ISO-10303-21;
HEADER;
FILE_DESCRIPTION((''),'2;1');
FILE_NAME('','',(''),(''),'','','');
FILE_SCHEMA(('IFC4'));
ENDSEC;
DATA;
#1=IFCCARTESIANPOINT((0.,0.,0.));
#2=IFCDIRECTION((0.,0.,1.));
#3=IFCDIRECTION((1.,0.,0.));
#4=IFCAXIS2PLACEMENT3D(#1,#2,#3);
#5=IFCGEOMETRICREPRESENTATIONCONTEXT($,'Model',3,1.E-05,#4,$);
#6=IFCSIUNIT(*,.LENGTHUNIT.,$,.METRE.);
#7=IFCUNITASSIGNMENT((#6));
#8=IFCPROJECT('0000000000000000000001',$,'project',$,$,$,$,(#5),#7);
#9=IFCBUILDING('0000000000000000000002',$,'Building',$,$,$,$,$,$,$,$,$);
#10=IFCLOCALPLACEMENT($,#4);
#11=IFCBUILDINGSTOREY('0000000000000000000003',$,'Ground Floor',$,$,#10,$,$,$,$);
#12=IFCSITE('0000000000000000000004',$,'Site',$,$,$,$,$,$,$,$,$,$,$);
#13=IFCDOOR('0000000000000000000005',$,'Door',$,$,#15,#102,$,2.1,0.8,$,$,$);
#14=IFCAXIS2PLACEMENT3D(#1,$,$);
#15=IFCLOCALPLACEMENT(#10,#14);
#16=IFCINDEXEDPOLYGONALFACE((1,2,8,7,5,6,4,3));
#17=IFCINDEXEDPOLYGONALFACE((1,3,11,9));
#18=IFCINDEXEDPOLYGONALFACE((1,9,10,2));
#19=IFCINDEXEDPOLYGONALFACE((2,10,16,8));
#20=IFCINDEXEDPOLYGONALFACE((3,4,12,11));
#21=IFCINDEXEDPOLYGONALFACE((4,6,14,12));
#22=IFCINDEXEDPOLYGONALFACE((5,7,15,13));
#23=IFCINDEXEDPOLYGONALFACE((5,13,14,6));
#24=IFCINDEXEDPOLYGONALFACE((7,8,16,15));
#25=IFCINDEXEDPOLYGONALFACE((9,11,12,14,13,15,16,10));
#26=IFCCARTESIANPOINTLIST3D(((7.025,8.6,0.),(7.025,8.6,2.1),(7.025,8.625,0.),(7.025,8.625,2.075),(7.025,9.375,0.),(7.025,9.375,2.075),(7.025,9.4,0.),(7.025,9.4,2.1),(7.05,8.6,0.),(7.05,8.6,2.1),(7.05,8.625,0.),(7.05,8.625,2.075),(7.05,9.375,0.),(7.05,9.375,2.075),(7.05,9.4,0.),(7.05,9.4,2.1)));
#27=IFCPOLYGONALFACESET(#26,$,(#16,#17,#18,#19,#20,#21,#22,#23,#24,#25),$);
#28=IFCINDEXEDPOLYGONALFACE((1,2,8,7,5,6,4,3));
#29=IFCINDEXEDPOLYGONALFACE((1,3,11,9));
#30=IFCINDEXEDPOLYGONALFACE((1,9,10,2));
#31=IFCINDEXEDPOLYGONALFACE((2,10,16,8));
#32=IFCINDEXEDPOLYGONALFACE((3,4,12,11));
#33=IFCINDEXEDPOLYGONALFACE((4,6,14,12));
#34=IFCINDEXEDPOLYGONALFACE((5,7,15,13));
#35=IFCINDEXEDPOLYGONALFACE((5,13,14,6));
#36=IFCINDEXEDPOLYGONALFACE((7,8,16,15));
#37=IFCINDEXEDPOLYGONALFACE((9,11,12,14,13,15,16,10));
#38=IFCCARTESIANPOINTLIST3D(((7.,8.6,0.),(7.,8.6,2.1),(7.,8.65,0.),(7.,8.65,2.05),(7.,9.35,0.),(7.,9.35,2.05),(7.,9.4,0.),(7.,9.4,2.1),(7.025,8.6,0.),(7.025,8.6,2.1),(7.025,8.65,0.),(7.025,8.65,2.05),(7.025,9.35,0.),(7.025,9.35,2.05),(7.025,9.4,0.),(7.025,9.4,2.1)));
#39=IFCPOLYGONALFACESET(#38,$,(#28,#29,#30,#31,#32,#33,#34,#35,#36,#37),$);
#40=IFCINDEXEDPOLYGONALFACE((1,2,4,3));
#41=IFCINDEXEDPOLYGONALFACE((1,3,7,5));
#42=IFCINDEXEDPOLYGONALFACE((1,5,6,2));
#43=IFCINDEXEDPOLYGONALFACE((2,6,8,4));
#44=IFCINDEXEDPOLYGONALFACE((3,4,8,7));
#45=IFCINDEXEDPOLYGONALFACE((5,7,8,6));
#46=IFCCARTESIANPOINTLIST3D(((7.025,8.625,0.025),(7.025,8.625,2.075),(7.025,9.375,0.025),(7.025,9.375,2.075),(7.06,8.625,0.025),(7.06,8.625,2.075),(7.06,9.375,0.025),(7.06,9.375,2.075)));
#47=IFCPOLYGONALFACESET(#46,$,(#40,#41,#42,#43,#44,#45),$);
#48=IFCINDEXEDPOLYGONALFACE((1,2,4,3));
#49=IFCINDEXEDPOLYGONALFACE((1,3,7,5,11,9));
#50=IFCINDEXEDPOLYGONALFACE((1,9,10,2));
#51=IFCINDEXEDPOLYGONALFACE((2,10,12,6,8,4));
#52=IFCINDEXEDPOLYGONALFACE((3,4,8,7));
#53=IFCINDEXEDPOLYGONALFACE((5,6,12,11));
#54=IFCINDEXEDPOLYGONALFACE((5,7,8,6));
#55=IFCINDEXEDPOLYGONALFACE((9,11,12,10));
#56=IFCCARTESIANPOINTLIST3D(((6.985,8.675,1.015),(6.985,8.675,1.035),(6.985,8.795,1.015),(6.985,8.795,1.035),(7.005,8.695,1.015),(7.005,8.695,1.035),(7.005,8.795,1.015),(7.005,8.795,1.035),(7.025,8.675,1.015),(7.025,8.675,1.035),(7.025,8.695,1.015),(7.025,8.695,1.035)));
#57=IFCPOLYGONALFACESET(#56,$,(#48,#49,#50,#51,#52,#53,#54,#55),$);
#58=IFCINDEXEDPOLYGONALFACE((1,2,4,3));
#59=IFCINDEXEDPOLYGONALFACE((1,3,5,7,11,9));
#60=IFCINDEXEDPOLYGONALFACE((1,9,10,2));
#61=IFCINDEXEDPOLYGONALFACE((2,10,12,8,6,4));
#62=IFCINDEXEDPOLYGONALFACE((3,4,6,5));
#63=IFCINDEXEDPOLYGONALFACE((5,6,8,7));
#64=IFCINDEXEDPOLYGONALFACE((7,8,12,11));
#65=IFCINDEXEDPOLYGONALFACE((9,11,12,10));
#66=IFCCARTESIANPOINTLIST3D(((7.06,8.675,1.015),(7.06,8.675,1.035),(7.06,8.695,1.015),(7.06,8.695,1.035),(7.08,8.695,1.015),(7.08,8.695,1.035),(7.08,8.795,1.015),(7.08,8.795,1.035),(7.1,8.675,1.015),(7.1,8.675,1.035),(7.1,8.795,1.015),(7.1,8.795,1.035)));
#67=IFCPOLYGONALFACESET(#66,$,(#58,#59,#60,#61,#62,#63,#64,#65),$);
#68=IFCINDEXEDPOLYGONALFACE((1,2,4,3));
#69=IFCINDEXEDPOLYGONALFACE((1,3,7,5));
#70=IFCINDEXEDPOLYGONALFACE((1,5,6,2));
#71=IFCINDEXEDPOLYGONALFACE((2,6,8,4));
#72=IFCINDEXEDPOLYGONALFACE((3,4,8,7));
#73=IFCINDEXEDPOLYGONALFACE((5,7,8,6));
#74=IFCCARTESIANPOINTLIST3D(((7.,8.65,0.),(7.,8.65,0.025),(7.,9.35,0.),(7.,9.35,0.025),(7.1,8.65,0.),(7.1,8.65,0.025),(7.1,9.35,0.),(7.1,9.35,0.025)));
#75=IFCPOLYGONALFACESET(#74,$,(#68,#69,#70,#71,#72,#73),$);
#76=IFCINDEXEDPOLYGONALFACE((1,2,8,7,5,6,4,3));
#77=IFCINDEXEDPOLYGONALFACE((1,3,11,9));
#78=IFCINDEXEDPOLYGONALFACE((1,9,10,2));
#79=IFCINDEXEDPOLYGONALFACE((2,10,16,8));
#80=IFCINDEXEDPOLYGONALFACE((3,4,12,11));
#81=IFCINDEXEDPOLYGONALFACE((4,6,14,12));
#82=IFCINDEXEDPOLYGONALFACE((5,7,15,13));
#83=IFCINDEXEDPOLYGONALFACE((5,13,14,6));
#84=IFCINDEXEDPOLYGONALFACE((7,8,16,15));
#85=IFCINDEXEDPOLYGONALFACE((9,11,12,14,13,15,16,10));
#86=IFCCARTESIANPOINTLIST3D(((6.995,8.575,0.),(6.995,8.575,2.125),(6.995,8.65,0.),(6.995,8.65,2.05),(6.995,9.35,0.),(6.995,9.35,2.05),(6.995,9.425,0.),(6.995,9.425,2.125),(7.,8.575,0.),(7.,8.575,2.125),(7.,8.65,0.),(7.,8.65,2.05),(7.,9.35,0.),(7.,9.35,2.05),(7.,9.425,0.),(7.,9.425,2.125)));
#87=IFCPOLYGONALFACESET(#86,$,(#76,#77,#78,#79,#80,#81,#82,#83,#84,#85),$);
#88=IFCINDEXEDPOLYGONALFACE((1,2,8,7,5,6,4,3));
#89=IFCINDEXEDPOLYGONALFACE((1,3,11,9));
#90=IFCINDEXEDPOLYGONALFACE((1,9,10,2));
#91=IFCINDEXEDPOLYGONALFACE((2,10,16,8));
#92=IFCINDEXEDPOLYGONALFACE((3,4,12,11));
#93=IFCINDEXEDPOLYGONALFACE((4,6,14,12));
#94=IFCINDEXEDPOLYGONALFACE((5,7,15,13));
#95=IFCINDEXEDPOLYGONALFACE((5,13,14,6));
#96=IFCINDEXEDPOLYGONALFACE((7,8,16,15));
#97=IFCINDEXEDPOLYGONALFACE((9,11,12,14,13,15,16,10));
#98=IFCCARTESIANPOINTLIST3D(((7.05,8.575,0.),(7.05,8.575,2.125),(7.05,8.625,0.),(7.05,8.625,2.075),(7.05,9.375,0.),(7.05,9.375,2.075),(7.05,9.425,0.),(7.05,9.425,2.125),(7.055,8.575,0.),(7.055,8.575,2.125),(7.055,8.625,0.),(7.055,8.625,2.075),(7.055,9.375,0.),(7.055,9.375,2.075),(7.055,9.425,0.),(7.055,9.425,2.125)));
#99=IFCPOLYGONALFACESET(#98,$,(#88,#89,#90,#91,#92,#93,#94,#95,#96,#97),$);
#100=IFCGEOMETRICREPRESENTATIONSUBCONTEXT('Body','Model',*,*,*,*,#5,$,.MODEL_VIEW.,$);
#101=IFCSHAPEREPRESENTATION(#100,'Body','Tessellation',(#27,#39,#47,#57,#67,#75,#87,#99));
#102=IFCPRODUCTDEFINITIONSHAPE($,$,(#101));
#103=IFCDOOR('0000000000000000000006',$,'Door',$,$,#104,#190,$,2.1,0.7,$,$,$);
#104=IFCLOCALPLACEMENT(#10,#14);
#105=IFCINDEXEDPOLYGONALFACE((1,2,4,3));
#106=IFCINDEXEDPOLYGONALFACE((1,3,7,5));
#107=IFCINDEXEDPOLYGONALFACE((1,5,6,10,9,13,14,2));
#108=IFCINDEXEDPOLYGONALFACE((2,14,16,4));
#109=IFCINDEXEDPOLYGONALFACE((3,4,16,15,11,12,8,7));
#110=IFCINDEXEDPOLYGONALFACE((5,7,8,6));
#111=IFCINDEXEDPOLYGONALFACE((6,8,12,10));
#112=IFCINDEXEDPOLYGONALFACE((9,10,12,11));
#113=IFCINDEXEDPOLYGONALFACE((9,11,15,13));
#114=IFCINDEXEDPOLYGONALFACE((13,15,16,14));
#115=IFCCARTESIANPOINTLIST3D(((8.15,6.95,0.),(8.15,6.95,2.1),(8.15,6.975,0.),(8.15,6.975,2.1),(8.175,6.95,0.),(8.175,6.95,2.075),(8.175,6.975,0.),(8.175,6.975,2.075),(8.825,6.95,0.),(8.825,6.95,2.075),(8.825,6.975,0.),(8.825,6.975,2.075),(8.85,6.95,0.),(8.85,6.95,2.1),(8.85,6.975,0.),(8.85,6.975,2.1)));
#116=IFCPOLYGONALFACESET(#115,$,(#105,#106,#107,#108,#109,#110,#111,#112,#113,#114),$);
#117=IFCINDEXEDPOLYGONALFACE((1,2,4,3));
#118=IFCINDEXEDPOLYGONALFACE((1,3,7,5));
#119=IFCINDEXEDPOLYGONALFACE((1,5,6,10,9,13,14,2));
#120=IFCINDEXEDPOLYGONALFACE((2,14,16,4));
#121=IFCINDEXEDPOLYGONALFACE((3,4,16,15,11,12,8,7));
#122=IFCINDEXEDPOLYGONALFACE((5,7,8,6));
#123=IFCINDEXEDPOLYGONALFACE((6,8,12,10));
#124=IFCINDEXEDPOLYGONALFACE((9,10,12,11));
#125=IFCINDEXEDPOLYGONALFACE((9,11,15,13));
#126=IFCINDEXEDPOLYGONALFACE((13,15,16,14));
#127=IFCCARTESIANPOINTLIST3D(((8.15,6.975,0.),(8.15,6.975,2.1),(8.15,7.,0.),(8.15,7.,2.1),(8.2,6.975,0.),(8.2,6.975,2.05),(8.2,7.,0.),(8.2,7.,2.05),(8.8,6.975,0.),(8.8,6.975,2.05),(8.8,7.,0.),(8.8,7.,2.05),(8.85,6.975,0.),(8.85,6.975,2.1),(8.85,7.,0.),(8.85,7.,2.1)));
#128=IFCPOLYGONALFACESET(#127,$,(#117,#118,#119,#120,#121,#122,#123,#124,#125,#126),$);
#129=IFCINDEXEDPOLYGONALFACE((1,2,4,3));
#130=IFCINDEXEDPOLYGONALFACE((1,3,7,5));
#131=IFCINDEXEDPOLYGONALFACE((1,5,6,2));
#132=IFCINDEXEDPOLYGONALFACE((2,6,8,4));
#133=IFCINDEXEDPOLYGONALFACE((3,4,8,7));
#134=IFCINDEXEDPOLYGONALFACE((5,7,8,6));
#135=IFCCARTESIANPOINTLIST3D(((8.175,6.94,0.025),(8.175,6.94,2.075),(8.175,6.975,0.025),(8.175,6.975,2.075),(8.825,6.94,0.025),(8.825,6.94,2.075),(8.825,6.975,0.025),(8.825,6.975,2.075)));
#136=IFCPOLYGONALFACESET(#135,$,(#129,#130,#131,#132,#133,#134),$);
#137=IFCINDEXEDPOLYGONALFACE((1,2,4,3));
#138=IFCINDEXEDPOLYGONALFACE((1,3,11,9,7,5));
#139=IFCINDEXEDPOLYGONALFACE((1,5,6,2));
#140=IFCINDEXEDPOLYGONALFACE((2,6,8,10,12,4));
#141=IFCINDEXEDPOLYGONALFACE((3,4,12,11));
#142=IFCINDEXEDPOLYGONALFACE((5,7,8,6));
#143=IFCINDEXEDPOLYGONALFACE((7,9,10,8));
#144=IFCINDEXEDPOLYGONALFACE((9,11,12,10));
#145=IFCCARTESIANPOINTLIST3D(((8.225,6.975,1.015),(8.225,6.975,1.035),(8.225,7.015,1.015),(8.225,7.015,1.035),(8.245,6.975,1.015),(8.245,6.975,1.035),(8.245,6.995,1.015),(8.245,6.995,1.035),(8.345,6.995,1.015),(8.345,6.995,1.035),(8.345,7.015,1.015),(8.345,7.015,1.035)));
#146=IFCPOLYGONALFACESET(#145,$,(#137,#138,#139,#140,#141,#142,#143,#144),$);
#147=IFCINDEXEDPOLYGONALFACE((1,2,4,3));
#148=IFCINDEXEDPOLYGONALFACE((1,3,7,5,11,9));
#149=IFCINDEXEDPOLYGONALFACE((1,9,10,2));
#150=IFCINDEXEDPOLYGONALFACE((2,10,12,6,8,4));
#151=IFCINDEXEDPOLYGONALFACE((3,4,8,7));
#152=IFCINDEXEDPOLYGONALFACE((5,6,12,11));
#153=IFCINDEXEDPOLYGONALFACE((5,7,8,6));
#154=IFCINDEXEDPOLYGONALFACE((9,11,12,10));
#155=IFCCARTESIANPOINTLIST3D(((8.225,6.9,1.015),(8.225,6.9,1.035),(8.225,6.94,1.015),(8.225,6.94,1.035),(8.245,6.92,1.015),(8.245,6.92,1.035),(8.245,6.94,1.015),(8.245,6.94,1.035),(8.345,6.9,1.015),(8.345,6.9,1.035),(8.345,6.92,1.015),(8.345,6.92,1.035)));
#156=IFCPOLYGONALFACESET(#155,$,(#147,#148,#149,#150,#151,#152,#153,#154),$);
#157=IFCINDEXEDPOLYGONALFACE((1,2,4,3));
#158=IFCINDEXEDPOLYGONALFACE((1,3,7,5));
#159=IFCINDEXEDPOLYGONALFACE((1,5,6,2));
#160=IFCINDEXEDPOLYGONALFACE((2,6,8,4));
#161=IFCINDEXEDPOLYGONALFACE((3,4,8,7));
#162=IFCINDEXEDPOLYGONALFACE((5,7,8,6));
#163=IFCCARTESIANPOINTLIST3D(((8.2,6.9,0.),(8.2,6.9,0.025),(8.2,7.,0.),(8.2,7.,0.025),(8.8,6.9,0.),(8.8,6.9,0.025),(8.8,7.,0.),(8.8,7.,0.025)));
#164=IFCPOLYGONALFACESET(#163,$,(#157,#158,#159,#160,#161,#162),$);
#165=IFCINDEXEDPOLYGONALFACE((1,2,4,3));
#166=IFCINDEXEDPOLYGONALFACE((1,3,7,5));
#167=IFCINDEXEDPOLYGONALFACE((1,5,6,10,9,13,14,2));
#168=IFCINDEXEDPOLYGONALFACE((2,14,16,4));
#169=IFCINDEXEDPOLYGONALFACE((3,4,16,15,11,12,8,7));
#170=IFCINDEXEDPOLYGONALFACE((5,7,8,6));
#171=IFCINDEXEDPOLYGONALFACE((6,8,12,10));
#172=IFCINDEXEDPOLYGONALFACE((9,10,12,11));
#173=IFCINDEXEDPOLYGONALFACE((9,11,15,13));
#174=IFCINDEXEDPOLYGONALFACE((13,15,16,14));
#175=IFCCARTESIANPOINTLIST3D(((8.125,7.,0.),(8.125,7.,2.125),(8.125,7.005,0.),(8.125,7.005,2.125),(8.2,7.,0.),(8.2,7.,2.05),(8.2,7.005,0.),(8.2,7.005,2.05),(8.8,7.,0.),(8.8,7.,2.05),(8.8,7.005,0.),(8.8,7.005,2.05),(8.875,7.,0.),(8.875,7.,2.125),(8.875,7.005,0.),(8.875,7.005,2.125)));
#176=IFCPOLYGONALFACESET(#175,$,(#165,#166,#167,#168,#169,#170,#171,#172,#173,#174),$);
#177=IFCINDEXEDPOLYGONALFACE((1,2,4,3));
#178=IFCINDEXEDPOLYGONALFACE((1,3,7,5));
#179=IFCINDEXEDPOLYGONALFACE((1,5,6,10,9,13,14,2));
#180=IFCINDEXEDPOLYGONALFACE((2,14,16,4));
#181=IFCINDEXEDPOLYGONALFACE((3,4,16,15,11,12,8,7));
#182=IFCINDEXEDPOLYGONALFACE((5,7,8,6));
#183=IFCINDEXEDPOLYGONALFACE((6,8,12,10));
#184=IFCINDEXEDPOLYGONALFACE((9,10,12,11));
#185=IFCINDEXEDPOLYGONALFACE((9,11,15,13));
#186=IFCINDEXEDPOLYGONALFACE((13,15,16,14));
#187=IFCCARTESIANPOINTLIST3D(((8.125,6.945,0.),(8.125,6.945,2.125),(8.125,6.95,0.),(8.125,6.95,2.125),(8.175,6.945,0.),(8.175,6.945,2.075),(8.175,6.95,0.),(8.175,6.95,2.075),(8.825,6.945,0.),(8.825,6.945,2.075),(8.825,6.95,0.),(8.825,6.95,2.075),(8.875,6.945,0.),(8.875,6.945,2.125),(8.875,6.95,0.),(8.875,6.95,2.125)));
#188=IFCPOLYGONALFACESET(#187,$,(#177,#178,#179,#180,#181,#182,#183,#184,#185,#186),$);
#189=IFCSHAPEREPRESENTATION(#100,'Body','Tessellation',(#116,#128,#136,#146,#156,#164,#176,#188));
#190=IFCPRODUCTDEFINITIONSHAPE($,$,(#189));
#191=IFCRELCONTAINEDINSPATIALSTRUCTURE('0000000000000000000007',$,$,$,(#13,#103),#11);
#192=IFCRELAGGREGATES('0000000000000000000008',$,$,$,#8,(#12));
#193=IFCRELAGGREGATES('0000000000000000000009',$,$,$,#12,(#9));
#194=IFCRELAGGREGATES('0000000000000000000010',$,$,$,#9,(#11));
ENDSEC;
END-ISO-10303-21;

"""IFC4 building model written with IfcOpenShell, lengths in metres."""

from ifc_helpers import new_model, si_unit, frame, origin_with_axes, place, context, subcontext, project, spatial, line, indexed_curve, outline, extrude, element, save


model = new_model("IFC4")

# Units and contexts
model_context = context("Model", 3, precision=1e-05, world=origin_with_axes())
body_context = subcontext(model_context, "Body", "Model", "MODEL_VIEW")
ifc_project = project(units=[si_unit("LENGTHUNIT", "METRE")], contexts=[model_context])

# Site, building, storey
site = spatial("IfcSite", under=ifc_project, Name="Site")
building = spatial("IfcBuilding", under=site, Name="Building")
storey_placement = place(None, origin_with_axes())
storey = spatial("IfcBuildingStorey", under=building, at=storey_placement, Name="Ground Floor")

# Doors
door_1_placement = place(storey_placement, frame((7.0, 9.4, 0.0), z_axis=(0.0, 0.0, 1.0), x_axis=(0.0, -1.0, 0.0)))
element("IfcDoor", 1, at=door_1_placement, inside=storey, Name="Door", OverallHeight=2.1, OverallWidth=0.8, context=body_context, shape_type="SweptSolid", body=[
    extrude(outline(indexed_curve([(0.0, 0.0), (0.0, 2.1), (0.8, 2.1), (0.8, 0.0), (0.775, 0.0), (0.775, 2.075), (0.025, 2.075), (0.025, 0.0)], segments=[line(1, 2, 3, 4, 5, 6, 7, 8, 1)])), frame((0.0, 0.025, 0.0), z_axis=(0.0, -1.0, 0.0), x_axis=(1.0, 0.0, 0.0)), (0.0, 0.0, -1.0), 0.025),
    extrude(outline(indexed_curve([(0.0, 0.0), (0.0, 2.1), (0.8, 2.1), (0.8, 0.0), (0.75, 0.0), (0.75, 2.05), (0.05, 2.05), (0.05, 0.0)], segments=[line(1, 2, 3, 4, 5, 6, 7, 8, 1)])), frame((0.0, 0.0, 0.0), z_axis=(0.0, -1.0, 0.0), x_axis=(1.0, 0.0, 0.0)), (0.0, 0.0, -1.0), 0.025),
    extrude(outline(indexed_curve([(0.0, 0.0), (0.75, 0.0), (0.75, 0.035), (0.0, 0.035)], segments=[line(1, 2, 3, 4, 1)])), frame((0.025, 0.025, 0.025), z_axis=(0.0, 0.0, 1.0), x_axis=(1.0, 0.0, 0.0)), (0.0, 0.0, 1.0), 2.05),
    extrude(outline(indexed_curve([(0.0, 0.0), (0.0, -0.04), (-0.12, -0.04), (-0.12, -0.02), (-0.02, -0.02), (-0.02, 0.0)], segments=[line(1, 2, 3, 4, 5, 6, 1)])), frame((0.725, 0.025, 1.015), z_axis=(0.0, 0.0, 1.0), x_axis=(1.0, 0.0, 0.0)), (0.0, 0.0, 1.0), 0.02),
    extrude(outline(indexed_curve([(0.0, 0.0), (0.0, 0.04), (-0.12, 0.04), (-0.12, 0.02), (-0.02, 0.02), (-0.02, 0.0)], segments=[line(1, 2, 3, 4, 5, 6, 1)])), frame((0.725, 0.06, 1.015), z_axis=(0.0, 0.0, 1.0), x_axis=(1.0, 0.0, 0.0)), (0.0, 0.0, 1.0), 0.02),
    extrude(outline(indexed_curve([(0.0, 0.0), (0.7, 0.0), (0.7, 0.1), (0.0, 0.1)], segments=[line(1, 2, 3, 4, 1)])), frame((0.05, 0.0, 0.0), z_axis=(0.0, 0.0, 1.0), x_axis=(1.0, 0.0, 0.0)), (0.0, 0.0, 1.0), 0.025),
    extrude(outline(indexed_curve([(0.0, 0.0), (0.0, 2.125), (0.85, 2.125), (0.85, 0.0), (0.775, 0.0), (0.775, 2.05), (0.075, 2.05), (0.075, 0.0)], segments=[line(1, 2, 3, 4, 5, 6, 7, 8, 1)])), frame((-0.025, -0.005, 0.0), z_axis=(0.0, -1.0, 0.0), x_axis=(1.0, 0.0, 0.0)), (0.0, 0.0, -1.0), 0.005),
    extrude(outline(indexed_curve([(0.0, 0.0), (0.0, 2.125), (0.85, 2.125), (0.85, 0.0), (0.8, 0.0), (0.8, 2.075), (0.05, 2.075), (0.05, 0.0)], segments=[line(1, 2, 3, 4, 5, 6, 7, 8, 1)])), frame((-0.025, 0.05, 0.0), z_axis=(0.0, -1.0, 0.0), x_axis=(1.0, 0.0, 0.0)), (0.0, 0.0, -1.0), 0.005),
])
door_2_placement = place(storey_placement, frame((8.85, 7.0, 0.0), z_axis=(0.0, 0.0, 1.0), x_axis=(-1.0, 0.0, 0.0)))
element("IfcDoor", 2, at=door_2_placement, inside=storey, Name="Door", OverallHeight=2.1, OverallWidth=0.7, context=body_context, shape_type="SweptSolid", body=[
    extrude(outline(indexed_curve([(0.0, 0.0), (0.0, 2.1), (0.7, 2.1), (0.7, 0.0), (0.675, 0.0), (0.675, 2.075), (0.025, 2.075), (0.025, 0.0)], segments=[line(1, 2, 3, 4, 5, 6, 7, 8, 1)])), frame((0.0, 0.025, 0.0), z_axis=(0.0, -1.0, 0.0), x_axis=(1.0, 0.0, 0.0)), (0.0, 0.0, -1.0), 0.025),
    extrude(outline(indexed_curve([(0.0, 0.0), (0.0, 2.1), (0.7, 2.1), (0.7, 0.0), (0.65, 0.0), (0.65, 2.05), (0.05, 2.05), (0.05, 0.0)], segments=[line(1, 2, 3, 4, 5, 6, 7, 8, 1)])), frame((0.0, 0.0, 0.0), z_axis=(0.0, -1.0, 0.0), x_axis=(1.0, 0.0, 0.0)), (0.0, 0.0, -1.0), 0.025),
    extrude(outline(indexed_curve([(0.0, 0.0), (0.65, 0.0), (0.65, 0.035), (0.0, 0.035)], segments=[line(1, 2, 3, 4, 1)])), frame((0.025, 0.025, 0.025), z_axis=(0.0, 0.0, 1.0), x_axis=(1.0, 0.0, 0.0)), (0.0, 0.0, 1.0), 2.05),
    extrude(outline(indexed_curve([(0.0, 0.0), (0.0, -0.04), (-0.12, -0.04), (-0.12, -0.02), (-0.02, -0.02), (-0.02, 0.0)], segments=[line(1, 2, 3, 4, 5, 6, 1)])), frame((0.625, 0.025, 1.015), z_axis=(0.0, 0.0, 1.0), x_axis=(1.0, 0.0, 0.0)), (0.0, 0.0, 1.0), 0.02),
    extrude(outline(indexed_curve([(0.0, 0.0), (0.0, 0.04), (-0.12, 0.04), (-0.12, 0.02), (-0.02, 0.02), (-0.02, 0.0)], segments=[line(1, 2, 3, 4, 5, 6, 1)])), frame((0.625, 0.06, 1.015), z_axis=(0.0, 0.0, 1.0), x_axis=(1.0, 0.0, 0.0)), (0.0, 0.0, 1.0), 0.02),
    extrude(outline(indexed_curve([(0.0, 0.0), (0.6, 0.0), (0.6, 0.1), (0.0, 0.1)], segments=[line(1, 2, 3, 4, 1)])), frame((0.05, 0.0, 0.0), z_axis=(0.0, 0.0, 1.0), x_axis=(1.0, 0.0, 0.0)), (0.0, 0.0, 1.0), 0.025),
    extrude(outline(indexed_curve([(0.0, 0.0), (0.0, 2.125), (0.75, 2.125), (0.75, 0.0), (0.675, 0.0), (0.675, 2.05), (0.075, 2.05), (0.075, 0.0)], segments=[line(1, 2, 3, 4, 5, 6, 7, 8, 1)])), frame((-0.025, -0.005, 0.0), z_axis=(0.0, -1.0, 0.0), x_axis=(1.0, 0.0, 0.0)), (0.0, 0.0, -1.0), 0.005),
    extrude(outline(indexed_curve([(0.0, 0.0), (0.0, 2.125), (0.75, 2.125), (0.75, 0.0), (0.7, 0.0), (0.7, 2.075), (0.05, 2.075), (0.05, 0.0)], segments=[line(1, 2, 3, 4, 5, 6, 7, 8, 1)])), frame((-0.025, 0.05, 0.0), z_axis=(0.0, -1.0, 0.0), x_axis=(1.0, 0.0, 0.0)), (0.0, 0.0, -1.0), 0.005),
])

save(model, "model.ifc")
